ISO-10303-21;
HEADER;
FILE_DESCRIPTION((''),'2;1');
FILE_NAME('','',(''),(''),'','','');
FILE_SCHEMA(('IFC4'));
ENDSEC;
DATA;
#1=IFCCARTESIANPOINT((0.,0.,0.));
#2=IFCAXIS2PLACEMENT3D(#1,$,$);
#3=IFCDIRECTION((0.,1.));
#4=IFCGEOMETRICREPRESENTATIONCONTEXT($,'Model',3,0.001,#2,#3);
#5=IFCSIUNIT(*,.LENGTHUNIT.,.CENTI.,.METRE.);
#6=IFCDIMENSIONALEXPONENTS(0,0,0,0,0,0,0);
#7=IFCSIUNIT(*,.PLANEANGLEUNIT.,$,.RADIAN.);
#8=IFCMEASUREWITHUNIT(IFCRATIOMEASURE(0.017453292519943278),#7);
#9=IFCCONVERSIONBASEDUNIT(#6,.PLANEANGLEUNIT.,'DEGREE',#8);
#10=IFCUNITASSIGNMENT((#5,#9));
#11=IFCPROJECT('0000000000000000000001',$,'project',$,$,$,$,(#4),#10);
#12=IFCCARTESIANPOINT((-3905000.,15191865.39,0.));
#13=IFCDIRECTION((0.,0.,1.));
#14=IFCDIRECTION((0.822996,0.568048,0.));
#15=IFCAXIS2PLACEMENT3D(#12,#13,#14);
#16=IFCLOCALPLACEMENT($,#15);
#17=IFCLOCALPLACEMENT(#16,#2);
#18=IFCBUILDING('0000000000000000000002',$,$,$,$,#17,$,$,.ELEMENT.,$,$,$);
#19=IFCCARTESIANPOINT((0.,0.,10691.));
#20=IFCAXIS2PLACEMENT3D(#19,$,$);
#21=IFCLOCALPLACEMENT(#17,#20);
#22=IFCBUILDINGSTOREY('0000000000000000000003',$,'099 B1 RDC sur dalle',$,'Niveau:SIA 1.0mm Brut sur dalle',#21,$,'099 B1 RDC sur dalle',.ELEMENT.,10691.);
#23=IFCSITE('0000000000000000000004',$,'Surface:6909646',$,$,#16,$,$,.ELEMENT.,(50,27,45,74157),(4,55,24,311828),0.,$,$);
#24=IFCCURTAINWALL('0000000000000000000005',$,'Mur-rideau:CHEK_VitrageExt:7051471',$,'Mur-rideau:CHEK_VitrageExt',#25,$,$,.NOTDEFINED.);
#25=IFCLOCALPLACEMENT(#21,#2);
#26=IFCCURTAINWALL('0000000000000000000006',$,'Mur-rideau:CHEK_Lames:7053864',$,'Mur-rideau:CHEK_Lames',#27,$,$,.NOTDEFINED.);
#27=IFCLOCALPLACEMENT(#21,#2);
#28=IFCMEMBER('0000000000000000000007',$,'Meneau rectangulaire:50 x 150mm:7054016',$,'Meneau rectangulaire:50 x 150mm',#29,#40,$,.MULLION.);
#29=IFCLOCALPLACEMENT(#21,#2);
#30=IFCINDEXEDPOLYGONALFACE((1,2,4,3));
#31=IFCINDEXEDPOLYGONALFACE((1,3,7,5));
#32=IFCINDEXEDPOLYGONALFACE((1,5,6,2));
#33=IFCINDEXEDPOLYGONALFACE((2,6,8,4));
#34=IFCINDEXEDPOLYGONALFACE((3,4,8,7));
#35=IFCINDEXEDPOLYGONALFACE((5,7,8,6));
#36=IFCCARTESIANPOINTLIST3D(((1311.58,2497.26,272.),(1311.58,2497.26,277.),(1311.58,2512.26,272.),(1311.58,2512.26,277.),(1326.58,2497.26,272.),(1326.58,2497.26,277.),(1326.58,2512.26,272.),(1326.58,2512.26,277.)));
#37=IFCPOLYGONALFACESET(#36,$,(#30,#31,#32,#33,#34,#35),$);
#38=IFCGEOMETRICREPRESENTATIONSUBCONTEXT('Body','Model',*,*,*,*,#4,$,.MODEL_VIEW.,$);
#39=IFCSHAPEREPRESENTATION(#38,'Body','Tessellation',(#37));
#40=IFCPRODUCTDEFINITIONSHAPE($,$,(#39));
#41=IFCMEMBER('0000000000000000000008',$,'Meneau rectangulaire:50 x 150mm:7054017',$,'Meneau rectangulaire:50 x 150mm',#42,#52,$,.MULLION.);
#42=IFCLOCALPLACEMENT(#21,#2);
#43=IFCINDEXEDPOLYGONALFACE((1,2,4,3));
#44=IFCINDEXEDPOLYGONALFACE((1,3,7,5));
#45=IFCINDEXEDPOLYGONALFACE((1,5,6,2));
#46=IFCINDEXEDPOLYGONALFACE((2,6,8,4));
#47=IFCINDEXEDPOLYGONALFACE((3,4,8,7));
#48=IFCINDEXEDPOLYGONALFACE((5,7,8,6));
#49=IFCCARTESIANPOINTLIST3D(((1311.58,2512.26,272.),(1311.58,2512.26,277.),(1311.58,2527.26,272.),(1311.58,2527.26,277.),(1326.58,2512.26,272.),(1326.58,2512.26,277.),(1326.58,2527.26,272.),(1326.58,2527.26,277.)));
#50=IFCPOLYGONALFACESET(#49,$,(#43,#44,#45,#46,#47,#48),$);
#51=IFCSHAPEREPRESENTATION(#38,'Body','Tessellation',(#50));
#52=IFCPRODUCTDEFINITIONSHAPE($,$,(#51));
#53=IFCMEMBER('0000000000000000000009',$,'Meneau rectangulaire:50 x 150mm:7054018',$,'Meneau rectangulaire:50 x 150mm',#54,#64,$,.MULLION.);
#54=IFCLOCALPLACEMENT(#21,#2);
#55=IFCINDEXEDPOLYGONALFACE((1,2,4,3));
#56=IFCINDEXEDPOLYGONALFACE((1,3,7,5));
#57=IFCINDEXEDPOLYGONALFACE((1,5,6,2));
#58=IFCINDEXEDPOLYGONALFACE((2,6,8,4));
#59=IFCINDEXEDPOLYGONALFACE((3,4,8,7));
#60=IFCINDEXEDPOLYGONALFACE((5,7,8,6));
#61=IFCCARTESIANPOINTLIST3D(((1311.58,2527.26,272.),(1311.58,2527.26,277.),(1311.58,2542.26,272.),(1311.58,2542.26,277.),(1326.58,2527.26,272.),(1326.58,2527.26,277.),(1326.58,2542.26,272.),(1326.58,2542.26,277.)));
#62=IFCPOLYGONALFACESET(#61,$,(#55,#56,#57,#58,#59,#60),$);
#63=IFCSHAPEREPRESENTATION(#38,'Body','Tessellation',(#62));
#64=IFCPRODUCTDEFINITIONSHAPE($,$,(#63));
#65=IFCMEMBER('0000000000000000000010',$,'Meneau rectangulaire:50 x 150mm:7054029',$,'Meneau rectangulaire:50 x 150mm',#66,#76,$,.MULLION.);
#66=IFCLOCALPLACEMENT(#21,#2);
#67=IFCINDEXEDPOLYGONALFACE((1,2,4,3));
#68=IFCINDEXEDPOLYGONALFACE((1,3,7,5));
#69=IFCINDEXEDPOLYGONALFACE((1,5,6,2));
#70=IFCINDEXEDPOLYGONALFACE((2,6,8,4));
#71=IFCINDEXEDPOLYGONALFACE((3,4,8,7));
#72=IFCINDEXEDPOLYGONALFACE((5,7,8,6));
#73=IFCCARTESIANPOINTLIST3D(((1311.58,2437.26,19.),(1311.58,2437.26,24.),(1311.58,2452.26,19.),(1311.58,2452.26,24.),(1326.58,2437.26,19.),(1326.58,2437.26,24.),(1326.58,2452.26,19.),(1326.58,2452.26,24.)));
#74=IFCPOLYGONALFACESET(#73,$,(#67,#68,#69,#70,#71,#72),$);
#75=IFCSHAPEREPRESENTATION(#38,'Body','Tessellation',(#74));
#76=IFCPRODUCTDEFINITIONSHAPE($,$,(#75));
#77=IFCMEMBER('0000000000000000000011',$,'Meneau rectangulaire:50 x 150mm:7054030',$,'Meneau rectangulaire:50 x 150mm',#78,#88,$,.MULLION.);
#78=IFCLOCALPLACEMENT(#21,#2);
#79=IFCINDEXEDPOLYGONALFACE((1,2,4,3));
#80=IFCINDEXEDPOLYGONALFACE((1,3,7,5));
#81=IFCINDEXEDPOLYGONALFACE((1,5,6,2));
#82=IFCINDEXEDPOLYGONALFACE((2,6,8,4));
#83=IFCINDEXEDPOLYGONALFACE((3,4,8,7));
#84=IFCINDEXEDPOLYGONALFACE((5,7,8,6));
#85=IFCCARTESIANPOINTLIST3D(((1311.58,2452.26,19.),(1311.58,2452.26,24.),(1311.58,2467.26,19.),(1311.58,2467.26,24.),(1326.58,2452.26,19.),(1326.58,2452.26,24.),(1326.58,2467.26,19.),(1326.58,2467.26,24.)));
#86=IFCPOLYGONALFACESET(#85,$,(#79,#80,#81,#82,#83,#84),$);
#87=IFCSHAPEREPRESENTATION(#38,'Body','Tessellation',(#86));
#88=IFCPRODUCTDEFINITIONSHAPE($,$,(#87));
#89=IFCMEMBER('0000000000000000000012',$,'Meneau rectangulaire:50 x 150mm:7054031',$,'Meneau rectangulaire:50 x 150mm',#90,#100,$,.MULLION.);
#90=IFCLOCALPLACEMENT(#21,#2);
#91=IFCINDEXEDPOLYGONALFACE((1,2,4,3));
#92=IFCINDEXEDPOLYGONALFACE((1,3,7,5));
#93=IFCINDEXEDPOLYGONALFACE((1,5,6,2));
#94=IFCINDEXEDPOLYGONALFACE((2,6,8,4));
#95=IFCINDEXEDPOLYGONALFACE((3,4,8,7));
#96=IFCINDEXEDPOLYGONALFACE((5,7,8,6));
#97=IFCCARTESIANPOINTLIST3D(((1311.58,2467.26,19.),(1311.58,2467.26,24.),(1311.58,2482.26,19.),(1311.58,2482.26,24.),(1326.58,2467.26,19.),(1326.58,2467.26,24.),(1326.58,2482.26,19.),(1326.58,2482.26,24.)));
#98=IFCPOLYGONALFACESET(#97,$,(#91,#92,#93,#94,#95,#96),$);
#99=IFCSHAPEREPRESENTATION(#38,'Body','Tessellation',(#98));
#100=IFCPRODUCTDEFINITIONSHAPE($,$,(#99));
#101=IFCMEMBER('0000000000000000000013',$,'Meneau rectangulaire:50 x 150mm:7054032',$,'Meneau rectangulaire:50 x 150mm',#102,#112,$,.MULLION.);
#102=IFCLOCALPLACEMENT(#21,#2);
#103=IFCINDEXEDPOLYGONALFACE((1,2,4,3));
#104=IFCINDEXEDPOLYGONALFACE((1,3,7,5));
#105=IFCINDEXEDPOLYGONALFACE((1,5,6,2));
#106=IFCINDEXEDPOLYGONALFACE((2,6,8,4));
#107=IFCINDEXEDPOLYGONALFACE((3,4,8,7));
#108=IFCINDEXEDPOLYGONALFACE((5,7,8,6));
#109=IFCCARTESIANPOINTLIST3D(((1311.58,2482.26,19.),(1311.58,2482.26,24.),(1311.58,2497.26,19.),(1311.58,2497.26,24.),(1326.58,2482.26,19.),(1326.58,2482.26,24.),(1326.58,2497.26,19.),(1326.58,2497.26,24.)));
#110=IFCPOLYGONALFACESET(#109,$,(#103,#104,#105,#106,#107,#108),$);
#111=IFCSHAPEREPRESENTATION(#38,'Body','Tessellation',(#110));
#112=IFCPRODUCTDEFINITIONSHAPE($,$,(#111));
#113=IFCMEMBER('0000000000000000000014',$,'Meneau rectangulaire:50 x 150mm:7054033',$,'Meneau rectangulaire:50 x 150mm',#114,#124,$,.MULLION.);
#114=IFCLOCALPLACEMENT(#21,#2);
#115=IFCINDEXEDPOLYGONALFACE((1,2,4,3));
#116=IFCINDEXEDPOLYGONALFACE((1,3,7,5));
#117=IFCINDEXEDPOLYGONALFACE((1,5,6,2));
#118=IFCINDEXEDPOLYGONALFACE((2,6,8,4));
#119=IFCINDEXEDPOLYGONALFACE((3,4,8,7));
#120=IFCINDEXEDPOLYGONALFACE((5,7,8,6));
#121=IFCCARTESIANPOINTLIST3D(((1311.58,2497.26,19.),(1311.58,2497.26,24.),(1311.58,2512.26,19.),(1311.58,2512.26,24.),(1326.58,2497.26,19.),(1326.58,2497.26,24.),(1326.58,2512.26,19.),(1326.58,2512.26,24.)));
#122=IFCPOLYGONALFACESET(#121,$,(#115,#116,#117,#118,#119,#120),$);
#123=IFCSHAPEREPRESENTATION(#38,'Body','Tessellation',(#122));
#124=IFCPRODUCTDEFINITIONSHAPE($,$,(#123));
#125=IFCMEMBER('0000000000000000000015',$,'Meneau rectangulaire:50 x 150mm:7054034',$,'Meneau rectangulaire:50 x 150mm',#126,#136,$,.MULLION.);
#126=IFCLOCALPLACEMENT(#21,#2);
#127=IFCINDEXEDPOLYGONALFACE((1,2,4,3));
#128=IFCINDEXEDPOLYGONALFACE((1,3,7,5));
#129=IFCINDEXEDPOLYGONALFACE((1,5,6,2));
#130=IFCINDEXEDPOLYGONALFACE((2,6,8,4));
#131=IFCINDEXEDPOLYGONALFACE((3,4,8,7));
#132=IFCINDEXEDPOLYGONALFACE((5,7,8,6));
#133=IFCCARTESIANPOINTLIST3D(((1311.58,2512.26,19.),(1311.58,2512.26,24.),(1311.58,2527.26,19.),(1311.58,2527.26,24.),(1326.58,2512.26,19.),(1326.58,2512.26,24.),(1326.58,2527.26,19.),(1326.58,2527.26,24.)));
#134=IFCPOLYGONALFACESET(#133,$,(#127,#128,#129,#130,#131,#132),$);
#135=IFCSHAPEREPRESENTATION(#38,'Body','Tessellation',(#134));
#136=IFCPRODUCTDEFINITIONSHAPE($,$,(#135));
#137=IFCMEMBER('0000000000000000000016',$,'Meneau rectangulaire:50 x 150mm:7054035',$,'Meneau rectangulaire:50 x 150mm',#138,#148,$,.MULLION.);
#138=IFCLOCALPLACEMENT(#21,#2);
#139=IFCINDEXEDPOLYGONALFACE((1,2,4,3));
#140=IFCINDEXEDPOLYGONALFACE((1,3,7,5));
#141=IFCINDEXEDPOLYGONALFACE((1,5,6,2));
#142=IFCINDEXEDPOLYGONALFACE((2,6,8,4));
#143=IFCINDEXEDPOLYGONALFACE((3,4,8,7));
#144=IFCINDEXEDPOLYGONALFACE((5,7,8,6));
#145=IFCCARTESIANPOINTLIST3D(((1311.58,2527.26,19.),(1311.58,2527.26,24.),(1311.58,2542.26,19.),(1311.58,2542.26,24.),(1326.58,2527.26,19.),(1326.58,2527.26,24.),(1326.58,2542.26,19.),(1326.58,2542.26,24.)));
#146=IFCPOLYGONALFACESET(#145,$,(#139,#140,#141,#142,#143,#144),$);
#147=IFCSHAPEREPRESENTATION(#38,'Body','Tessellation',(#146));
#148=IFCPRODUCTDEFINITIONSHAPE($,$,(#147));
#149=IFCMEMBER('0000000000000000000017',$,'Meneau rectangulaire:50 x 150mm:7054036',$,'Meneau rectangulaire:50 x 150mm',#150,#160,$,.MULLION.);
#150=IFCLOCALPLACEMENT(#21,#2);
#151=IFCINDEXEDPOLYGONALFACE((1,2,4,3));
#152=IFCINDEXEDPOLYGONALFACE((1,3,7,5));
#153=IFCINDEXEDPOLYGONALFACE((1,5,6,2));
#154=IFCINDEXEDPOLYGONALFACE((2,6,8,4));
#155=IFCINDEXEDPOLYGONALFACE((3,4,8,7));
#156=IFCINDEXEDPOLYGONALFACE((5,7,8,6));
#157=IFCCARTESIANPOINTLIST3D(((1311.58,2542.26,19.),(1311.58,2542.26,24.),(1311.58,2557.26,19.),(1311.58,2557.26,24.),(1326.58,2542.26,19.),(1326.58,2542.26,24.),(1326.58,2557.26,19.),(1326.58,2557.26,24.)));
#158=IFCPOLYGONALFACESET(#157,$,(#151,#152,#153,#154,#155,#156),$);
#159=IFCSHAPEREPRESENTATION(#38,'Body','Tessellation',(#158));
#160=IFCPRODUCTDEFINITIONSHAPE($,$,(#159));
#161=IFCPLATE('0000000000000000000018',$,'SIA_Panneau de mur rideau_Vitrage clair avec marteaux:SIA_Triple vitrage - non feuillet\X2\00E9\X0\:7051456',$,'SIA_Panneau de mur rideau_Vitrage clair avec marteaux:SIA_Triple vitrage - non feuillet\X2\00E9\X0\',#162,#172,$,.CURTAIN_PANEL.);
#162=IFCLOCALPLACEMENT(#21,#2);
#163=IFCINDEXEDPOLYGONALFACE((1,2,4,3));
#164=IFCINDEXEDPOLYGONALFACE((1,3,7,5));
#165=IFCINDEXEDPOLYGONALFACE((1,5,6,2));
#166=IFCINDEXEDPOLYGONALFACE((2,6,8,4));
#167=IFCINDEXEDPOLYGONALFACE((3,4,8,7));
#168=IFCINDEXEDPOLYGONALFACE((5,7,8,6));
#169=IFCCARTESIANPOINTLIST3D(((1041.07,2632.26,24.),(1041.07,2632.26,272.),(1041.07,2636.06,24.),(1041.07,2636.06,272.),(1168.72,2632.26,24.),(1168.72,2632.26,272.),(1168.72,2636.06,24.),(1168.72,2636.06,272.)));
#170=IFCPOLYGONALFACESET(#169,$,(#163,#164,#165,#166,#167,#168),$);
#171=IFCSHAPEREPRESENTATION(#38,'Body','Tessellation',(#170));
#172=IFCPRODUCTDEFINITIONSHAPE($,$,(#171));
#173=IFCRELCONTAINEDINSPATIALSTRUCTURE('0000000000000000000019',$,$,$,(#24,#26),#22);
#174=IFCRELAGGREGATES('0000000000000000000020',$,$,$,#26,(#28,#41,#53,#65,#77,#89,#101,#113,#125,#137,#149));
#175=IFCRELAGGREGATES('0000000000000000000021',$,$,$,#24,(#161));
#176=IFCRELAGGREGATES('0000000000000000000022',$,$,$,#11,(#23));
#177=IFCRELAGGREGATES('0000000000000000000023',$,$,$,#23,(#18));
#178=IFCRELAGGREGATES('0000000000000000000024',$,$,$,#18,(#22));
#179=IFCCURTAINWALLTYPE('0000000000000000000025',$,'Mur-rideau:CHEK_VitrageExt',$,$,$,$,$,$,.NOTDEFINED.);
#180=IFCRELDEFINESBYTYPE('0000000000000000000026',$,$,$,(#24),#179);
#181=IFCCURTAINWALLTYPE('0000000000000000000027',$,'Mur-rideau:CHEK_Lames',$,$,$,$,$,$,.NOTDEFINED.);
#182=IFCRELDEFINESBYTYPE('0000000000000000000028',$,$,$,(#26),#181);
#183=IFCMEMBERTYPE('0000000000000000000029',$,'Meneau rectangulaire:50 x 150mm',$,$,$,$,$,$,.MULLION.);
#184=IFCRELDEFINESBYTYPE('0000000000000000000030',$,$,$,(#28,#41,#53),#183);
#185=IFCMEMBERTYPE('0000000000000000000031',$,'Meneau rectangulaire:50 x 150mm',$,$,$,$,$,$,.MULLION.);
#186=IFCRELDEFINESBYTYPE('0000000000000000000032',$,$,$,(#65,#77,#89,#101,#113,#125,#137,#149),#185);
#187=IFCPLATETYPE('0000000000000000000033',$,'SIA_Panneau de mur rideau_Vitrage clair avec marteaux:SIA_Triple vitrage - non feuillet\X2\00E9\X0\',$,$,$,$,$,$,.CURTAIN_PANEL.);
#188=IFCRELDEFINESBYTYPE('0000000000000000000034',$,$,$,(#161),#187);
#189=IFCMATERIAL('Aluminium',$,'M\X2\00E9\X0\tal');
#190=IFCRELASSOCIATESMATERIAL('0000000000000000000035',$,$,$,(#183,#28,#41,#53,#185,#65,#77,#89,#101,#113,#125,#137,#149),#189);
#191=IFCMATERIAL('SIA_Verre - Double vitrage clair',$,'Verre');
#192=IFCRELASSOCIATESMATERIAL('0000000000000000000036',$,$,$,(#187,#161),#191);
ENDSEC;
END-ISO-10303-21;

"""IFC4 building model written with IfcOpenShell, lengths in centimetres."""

from ifc_helpers import new_model, entity, si_unit, converted_unit, direction, frame, origin, place, context, subcontext, project, spatial, indexed_curve, outline, extrude, source, transform, mapped, material, type_object, type_shapes, element, aggregate, save


model = new_model("IFC4")

# Units and contexts
model_context = context("Model", 3, precision=0.001, world=origin(), true_north=direction((0.0, 1.0)))
body_context = subcontext(model_context, "Body", "Model", "MODEL_VIEW")
ifc_project = project(units=[si_unit("LENGTHUNIT", "METRE", prefix="CENTI"), converted_unit("PLANEANGLEUNIT", "DEGREE", entity("IfcRatioMeasure", 0.017453292519943278), si_unit("PLANEANGLEUNIT", "RADIAN"), dimensions=[0, 0, 0, 0, 0, 0, 0])], contexts=[model_context])

# Site, building, storey
site_placement = place(None, frame((-3905000.0, 15191865.39, 0.0), z_axis=(0.0, 0.0, 1.0), x_axis=(0.822996, 0.568048, 0.0)))
site = spatial("IfcSite", under=ifc_project, at=site_placement, Name="Surface:6909646", CompositionType="ELEMENT", RefLatitude=(50, 27, 45, 74157), RefLongitude=(4, 55, 24, 311828), RefElevation=0.0)
building_placement = place(site_placement, origin())
building = spatial("IfcBuilding", under=site, at=building_placement, CompositionType="ELEMENT")
storey_placement = place(building_placement, frame((0.0, 0.0, 10691.0)))
storey = spatial("IfcBuildingStorey", under=building, at=storey_placement, Name="099 B1 RDC sur dalle", ObjectType="Niveau:SIA 1.0mm Brut sur dalle", LongName="099 B1 RDC sur dalle", CompositionType="ELEMENT", Elevation=10691.0)

# Curtain wall
curtain_wall_type_1 = type_object("IfcCurtainWallType", Name="Mur-rideau:CHEK_VitrageExt", PredefinedType="NOTDEFINED")
curtain_wall_1_placement = place(storey_placement, frame((0.0, 0.0, -10691.0)))
curtain_wall_1 = element("IfcCurtainWall", 1, at=curtain_wall_1_placement, inside=storey, type_object=curtain_wall_type_1, Name="Mur-rideau:CHEK_VitrageExt:7051471", ObjectType="Mur-rideau:CHEK_VitrageExt", PredefinedType="NOTDEFINED")
ifc_material_1 = material(Name="Aluminium", Category="Métal")

# Curtain wall
curtain_wall_type_2 = type_object("IfcCurtainWallType", Name="Mur-rideau:CHEK_Lames", PredefinedType="NOTDEFINED")
curtain_wall_2_placement = place(storey_placement, frame((0.0, 0.0, -10691.0)))
curtain_wall_2 = element("IfcCurtainWall", 2, at=curtain_wall_2_placement, inside=storey, type_object=curtain_wall_type_2, Name="Mur-rideau:CHEK_Lames:7053864", ObjectType="Mur-rideau:CHEK_Lames", PredefinedType="NOTDEFINED")

# Members
member_type_1 = type_object("IfcMemberType", Name="Meneau rectangulaire:50 x 150mm", PredefinedType="MULLION", material=ifc_material_1)
shared_shape_1 = source(origin(), body_context, "Body", "SweptSolid", [
    extrude(outline(indexed_curve([(-7.5, -2.5), (7.5, -2.5), (7.5, 2.5), (-7.5, 2.5), (-7.5, -2.5)], self_intersect=False)), frame((-2.5, -6.0, -15.0), z_axis=(0.0, 0.0, 1.0), x_axis=(0.0, -1.0, 0.0)), (0.0, 0.0, 1.0), 15.0),
])
type_shapes(member_type_1, [shared_shape_1])
member_1_placement = place(curtain_wall_2_placement, frame((1325.08, 2512.26, 10968.0), z_axis=(0.0, 1.0, 0.0), x_axis=(0.0, 0.0, 1.0)))
member_1 = element("IfcMember", 3, at=member_1_placement, type_object=member_type_1, material=ifc_material_1, Name="Meneau rectangulaire:50 x 150mm:7054016", ObjectType="Meneau rectangulaire:50 x 150mm", PredefinedType="MULLION", context=body_context, shape_type="MappedRepresentation", body=[
    mapped(shared_shape_1, transform((0.0, 0.0, 0.0), scale=1.0)),
])
member_2_placement = place(curtain_wall_2_placement, frame((1325.08, 2527.26, 10968.0), z_axis=(0.0, 1.0, 0.0), x_axis=(0.0, 0.0, 1.0)))
member_2 = element("IfcMember", 4, at=member_2_placement, type_object=member_type_1, material=ifc_material_1, Name="Meneau rectangulaire:50 x 150mm:7054017", ObjectType="Meneau rectangulaire:50 x 150mm", PredefinedType="MULLION", context=body_context, shape_type="MappedRepresentation", body=[
    mapped(shared_shape_1, transform((0.0, 0.0, 0.0), scale=1.0)),
])
member_3_placement = place(curtain_wall_2_placement, frame((1325.08, 2542.26, 10968.0), z_axis=(0.0, 1.0, 0.0), x_axis=(0.0, 0.0, 1.0)))
member_3 = element("IfcMember", 5, at=member_3_placement, type_object=member_type_1, material=ifc_material_1, Name="Meneau rectangulaire:50 x 150mm:7054018", ObjectType="Meneau rectangulaire:50 x 150mm", PredefinedType="MULLION", context=body_context, shape_type="MappedRepresentation", body=[
    mapped(shared_shape_1, transform((0.0, 0.0, 0.0), scale=1.0)),
])
member_type_2 = type_object("IfcMemberType", Name="Meneau rectangulaire:50 x 150mm", PredefinedType="MULLION", material=ifc_material_1)
shared_shape_2 = source(origin(), body_context, "Body", "SweptSolid", [
    extrude(outline(indexed_curve([(-7.5, -2.5), (7.5, -2.5), (7.5, 2.5), (-7.5, 2.5), (-7.5, -2.5)], self_intersect=False)), frame((-2.5, -6.0, -15.0), z_axis=(0.0, 0.0, 1.0), x_axis=(0.0, -1.0, 0.0)), (0.0, 0.0, 1.0), 15.0),
])
type_shapes(member_type_2, [shared_shape_2])
member_4_placement = place(curtain_wall_2_placement, frame((1325.08, 2437.26, 10710.0), z_axis=(0.0, -1.0, 0.0), x_axis=(0.0, 0.0, -1.0)))
member_4 = element("IfcMember", 6, at=member_4_placement, type_object=member_type_2, material=ifc_material_1, Name="Meneau rectangulaire:50 x 150mm:7054029", ObjectType="Meneau rectangulaire:50 x 150mm", PredefinedType="MULLION", context=body_context, shape_type="MappedRepresentation", body=[
    mapped(shared_shape_2, transform((0.0, 0.0, 0.0), scale=1.0)),
])
member_5_placement = place(curtain_wall_2_placement, frame((1325.08, 2452.26, 10710.0), z_axis=(0.0, -1.0, 0.0), x_axis=(0.0, 0.0, -1.0)))
member_5 = element("IfcMember", 7, at=member_5_placement, type_object=member_type_2, material=ifc_material_1, Name="Meneau rectangulaire:50 x 150mm:7054030", ObjectType="Meneau rectangulaire:50 x 150mm", PredefinedType="MULLION", context=body_context, shape_type="MappedRepresentation", body=[
    mapped(shared_shape_2, transform((0.0, 0.0, 0.0), scale=1.0)),
])
member_6_placement = place(curtain_wall_2_placement, frame((1325.08, 2467.26, 10710.0), z_axis=(0.0, -1.0, 0.0), x_axis=(0.0, 0.0, -1.0)))
member_6 = element("IfcMember", 8, at=member_6_placement, type_object=member_type_2, material=ifc_material_1, Name="Meneau rectangulaire:50 x 150mm:7054031", ObjectType="Meneau rectangulaire:50 x 150mm", PredefinedType="MULLION", context=body_context, shape_type="MappedRepresentation", body=[
    mapped(shared_shape_2, transform((0.0, 0.0, 0.0), scale=1.0)),
])
member_7_placement = place(curtain_wall_2_placement, frame((1325.08, 2482.26, 10710.0), z_axis=(0.0, -1.0, 0.0), x_axis=(0.0, 0.0, -1.0)))
member_7 = element("IfcMember", 9, at=member_7_placement, type_object=member_type_2, material=ifc_material_1, Name="Meneau rectangulaire:50 x 150mm:7054032", ObjectType="Meneau rectangulaire:50 x 150mm", PredefinedType="MULLION", context=body_context, shape_type="MappedRepresentation", body=[
    mapped(shared_shape_2, transform((0.0, 0.0, 0.0), scale=1.0)),
])
member_8_placement = place(curtain_wall_2_placement, frame((1325.08, 2497.26, 10710.0), z_axis=(0.0, -1.0, 0.0), x_axis=(0.0, 0.0, -1.0)))
member_8 = element("IfcMember", 10, at=member_8_placement, type_object=member_type_2, material=ifc_material_1, Name="Meneau rectangulaire:50 x 150mm:7054033", ObjectType="Meneau rectangulaire:50 x 150mm", PredefinedType="MULLION", context=body_context, shape_type="MappedRepresentation", body=[
    mapped(shared_shape_2, transform((0.0, 0.0, 0.0), scale=1.0)),
])
member_9_placement = place(curtain_wall_2_placement, frame((1325.08, 2512.26, 10710.0), z_axis=(0.0, -1.0, 0.0), x_axis=(0.0, 0.0, -1.0)))
member_9 = element("IfcMember", 11, at=member_9_placement, type_object=member_type_2, material=ifc_material_1, Name="Meneau rectangulaire:50 x 150mm:7054034", ObjectType="Meneau rectangulaire:50 x 150mm", PredefinedType="MULLION", context=body_context, shape_type="MappedRepresentation", body=[
    mapped(shared_shape_2, transform((0.0, 0.0, 0.0), scale=1.0)),
])
member_10_placement = place(curtain_wall_2_placement, frame((1325.08, 2527.26, 10710.0), z_axis=(0.0, -1.0, 0.0), x_axis=(0.0, 0.0, -1.0)))
member_10 = element("IfcMember", 12, at=member_10_placement, type_object=member_type_2, material=ifc_material_1, Name="Meneau rectangulaire:50 x 150mm:7054035", ObjectType="Meneau rectangulaire:50 x 150mm", PredefinedType="MULLION", context=body_context, shape_type="MappedRepresentation", body=[
    mapped(shared_shape_2, transform((0.0, 0.0, 0.0), scale=1.0)),
])
member_11_placement = place(curtain_wall_2_placement, frame((1325.08, 2542.26, 10710.0), z_axis=(0.0, -1.0, 0.0), x_axis=(0.0, 0.0, -1.0)))
member_11 = element("IfcMember", 13, at=member_11_placement, type_object=member_type_2, material=ifc_material_1, Name="Meneau rectangulaire:50 x 150mm:7054036", ObjectType="Meneau rectangulaire:50 x 150mm", PredefinedType="MULLION", context=body_context, shape_type="MappedRepresentation", body=[
    mapped(shared_shape_2, transform((0.0, 0.0, 0.0), scale=1.0)),
])
aggregate(curtain_wall_2, [member_1, member_2, member_3, member_4, member_5, member_6, member_7, member_8, member_9, member_10, member_11])

# Plate
ifc_material_2 = material(Name="SIA_Verre - Double vitrage clair", Category="Verre")
plate_type = type_object("IfcPlateType", Name="SIA_Panneau de mur rideau_Vitrage clair avec marteaux:SIA_Triple vitrage - non feuilleté", PredefinedType="CURTAIN_PANEL", material=ifc_material_2)
shared_shape_3 = source(origin(), body_context, "Body", "SweptSolid", [
    extrude(outline(indexed_curve([(-63.83, -1.9), (63.83, -1.9), (63.83, 1.9), (-63.83, 1.9), (-63.83, -1.9)], self_intersect=False)), frame((0.0, 1.9, 0.0), z_axis=(0.0, 0.0, 1.0), x_axis=(-1.0, 0.0, 0.0)), (0.0, 0.0, 1.0), 248.0),
])
type_shapes(plate_type, [shared_shape_3])
plate_placement = place(curtain_wall_1_placement, frame((1104.9, 2632.26, 10715.0)))
plate = element("IfcPlate", 14, at=plate_placement, type_object=plate_type, material=ifc_material_2, Name="SIA_Panneau de mur rideau_Vitrage clair avec marteaux:SIA_Triple vitrage - non feuilleté:7051456", ObjectType="SIA_Panneau de mur rideau_Vitrage clair avec marteaux:SIA_Triple vitrage - non feuilleté", PredefinedType="CURTAIN_PANEL", context=body_context, shape_type="MappedRepresentation", body=[
    mapped(shared_shape_3, transform((0.0, 0.0, 0.0), scale=1.0)),
])
aggregate(curtain_wall_1, [plate])

save(model, "model.ifc")
